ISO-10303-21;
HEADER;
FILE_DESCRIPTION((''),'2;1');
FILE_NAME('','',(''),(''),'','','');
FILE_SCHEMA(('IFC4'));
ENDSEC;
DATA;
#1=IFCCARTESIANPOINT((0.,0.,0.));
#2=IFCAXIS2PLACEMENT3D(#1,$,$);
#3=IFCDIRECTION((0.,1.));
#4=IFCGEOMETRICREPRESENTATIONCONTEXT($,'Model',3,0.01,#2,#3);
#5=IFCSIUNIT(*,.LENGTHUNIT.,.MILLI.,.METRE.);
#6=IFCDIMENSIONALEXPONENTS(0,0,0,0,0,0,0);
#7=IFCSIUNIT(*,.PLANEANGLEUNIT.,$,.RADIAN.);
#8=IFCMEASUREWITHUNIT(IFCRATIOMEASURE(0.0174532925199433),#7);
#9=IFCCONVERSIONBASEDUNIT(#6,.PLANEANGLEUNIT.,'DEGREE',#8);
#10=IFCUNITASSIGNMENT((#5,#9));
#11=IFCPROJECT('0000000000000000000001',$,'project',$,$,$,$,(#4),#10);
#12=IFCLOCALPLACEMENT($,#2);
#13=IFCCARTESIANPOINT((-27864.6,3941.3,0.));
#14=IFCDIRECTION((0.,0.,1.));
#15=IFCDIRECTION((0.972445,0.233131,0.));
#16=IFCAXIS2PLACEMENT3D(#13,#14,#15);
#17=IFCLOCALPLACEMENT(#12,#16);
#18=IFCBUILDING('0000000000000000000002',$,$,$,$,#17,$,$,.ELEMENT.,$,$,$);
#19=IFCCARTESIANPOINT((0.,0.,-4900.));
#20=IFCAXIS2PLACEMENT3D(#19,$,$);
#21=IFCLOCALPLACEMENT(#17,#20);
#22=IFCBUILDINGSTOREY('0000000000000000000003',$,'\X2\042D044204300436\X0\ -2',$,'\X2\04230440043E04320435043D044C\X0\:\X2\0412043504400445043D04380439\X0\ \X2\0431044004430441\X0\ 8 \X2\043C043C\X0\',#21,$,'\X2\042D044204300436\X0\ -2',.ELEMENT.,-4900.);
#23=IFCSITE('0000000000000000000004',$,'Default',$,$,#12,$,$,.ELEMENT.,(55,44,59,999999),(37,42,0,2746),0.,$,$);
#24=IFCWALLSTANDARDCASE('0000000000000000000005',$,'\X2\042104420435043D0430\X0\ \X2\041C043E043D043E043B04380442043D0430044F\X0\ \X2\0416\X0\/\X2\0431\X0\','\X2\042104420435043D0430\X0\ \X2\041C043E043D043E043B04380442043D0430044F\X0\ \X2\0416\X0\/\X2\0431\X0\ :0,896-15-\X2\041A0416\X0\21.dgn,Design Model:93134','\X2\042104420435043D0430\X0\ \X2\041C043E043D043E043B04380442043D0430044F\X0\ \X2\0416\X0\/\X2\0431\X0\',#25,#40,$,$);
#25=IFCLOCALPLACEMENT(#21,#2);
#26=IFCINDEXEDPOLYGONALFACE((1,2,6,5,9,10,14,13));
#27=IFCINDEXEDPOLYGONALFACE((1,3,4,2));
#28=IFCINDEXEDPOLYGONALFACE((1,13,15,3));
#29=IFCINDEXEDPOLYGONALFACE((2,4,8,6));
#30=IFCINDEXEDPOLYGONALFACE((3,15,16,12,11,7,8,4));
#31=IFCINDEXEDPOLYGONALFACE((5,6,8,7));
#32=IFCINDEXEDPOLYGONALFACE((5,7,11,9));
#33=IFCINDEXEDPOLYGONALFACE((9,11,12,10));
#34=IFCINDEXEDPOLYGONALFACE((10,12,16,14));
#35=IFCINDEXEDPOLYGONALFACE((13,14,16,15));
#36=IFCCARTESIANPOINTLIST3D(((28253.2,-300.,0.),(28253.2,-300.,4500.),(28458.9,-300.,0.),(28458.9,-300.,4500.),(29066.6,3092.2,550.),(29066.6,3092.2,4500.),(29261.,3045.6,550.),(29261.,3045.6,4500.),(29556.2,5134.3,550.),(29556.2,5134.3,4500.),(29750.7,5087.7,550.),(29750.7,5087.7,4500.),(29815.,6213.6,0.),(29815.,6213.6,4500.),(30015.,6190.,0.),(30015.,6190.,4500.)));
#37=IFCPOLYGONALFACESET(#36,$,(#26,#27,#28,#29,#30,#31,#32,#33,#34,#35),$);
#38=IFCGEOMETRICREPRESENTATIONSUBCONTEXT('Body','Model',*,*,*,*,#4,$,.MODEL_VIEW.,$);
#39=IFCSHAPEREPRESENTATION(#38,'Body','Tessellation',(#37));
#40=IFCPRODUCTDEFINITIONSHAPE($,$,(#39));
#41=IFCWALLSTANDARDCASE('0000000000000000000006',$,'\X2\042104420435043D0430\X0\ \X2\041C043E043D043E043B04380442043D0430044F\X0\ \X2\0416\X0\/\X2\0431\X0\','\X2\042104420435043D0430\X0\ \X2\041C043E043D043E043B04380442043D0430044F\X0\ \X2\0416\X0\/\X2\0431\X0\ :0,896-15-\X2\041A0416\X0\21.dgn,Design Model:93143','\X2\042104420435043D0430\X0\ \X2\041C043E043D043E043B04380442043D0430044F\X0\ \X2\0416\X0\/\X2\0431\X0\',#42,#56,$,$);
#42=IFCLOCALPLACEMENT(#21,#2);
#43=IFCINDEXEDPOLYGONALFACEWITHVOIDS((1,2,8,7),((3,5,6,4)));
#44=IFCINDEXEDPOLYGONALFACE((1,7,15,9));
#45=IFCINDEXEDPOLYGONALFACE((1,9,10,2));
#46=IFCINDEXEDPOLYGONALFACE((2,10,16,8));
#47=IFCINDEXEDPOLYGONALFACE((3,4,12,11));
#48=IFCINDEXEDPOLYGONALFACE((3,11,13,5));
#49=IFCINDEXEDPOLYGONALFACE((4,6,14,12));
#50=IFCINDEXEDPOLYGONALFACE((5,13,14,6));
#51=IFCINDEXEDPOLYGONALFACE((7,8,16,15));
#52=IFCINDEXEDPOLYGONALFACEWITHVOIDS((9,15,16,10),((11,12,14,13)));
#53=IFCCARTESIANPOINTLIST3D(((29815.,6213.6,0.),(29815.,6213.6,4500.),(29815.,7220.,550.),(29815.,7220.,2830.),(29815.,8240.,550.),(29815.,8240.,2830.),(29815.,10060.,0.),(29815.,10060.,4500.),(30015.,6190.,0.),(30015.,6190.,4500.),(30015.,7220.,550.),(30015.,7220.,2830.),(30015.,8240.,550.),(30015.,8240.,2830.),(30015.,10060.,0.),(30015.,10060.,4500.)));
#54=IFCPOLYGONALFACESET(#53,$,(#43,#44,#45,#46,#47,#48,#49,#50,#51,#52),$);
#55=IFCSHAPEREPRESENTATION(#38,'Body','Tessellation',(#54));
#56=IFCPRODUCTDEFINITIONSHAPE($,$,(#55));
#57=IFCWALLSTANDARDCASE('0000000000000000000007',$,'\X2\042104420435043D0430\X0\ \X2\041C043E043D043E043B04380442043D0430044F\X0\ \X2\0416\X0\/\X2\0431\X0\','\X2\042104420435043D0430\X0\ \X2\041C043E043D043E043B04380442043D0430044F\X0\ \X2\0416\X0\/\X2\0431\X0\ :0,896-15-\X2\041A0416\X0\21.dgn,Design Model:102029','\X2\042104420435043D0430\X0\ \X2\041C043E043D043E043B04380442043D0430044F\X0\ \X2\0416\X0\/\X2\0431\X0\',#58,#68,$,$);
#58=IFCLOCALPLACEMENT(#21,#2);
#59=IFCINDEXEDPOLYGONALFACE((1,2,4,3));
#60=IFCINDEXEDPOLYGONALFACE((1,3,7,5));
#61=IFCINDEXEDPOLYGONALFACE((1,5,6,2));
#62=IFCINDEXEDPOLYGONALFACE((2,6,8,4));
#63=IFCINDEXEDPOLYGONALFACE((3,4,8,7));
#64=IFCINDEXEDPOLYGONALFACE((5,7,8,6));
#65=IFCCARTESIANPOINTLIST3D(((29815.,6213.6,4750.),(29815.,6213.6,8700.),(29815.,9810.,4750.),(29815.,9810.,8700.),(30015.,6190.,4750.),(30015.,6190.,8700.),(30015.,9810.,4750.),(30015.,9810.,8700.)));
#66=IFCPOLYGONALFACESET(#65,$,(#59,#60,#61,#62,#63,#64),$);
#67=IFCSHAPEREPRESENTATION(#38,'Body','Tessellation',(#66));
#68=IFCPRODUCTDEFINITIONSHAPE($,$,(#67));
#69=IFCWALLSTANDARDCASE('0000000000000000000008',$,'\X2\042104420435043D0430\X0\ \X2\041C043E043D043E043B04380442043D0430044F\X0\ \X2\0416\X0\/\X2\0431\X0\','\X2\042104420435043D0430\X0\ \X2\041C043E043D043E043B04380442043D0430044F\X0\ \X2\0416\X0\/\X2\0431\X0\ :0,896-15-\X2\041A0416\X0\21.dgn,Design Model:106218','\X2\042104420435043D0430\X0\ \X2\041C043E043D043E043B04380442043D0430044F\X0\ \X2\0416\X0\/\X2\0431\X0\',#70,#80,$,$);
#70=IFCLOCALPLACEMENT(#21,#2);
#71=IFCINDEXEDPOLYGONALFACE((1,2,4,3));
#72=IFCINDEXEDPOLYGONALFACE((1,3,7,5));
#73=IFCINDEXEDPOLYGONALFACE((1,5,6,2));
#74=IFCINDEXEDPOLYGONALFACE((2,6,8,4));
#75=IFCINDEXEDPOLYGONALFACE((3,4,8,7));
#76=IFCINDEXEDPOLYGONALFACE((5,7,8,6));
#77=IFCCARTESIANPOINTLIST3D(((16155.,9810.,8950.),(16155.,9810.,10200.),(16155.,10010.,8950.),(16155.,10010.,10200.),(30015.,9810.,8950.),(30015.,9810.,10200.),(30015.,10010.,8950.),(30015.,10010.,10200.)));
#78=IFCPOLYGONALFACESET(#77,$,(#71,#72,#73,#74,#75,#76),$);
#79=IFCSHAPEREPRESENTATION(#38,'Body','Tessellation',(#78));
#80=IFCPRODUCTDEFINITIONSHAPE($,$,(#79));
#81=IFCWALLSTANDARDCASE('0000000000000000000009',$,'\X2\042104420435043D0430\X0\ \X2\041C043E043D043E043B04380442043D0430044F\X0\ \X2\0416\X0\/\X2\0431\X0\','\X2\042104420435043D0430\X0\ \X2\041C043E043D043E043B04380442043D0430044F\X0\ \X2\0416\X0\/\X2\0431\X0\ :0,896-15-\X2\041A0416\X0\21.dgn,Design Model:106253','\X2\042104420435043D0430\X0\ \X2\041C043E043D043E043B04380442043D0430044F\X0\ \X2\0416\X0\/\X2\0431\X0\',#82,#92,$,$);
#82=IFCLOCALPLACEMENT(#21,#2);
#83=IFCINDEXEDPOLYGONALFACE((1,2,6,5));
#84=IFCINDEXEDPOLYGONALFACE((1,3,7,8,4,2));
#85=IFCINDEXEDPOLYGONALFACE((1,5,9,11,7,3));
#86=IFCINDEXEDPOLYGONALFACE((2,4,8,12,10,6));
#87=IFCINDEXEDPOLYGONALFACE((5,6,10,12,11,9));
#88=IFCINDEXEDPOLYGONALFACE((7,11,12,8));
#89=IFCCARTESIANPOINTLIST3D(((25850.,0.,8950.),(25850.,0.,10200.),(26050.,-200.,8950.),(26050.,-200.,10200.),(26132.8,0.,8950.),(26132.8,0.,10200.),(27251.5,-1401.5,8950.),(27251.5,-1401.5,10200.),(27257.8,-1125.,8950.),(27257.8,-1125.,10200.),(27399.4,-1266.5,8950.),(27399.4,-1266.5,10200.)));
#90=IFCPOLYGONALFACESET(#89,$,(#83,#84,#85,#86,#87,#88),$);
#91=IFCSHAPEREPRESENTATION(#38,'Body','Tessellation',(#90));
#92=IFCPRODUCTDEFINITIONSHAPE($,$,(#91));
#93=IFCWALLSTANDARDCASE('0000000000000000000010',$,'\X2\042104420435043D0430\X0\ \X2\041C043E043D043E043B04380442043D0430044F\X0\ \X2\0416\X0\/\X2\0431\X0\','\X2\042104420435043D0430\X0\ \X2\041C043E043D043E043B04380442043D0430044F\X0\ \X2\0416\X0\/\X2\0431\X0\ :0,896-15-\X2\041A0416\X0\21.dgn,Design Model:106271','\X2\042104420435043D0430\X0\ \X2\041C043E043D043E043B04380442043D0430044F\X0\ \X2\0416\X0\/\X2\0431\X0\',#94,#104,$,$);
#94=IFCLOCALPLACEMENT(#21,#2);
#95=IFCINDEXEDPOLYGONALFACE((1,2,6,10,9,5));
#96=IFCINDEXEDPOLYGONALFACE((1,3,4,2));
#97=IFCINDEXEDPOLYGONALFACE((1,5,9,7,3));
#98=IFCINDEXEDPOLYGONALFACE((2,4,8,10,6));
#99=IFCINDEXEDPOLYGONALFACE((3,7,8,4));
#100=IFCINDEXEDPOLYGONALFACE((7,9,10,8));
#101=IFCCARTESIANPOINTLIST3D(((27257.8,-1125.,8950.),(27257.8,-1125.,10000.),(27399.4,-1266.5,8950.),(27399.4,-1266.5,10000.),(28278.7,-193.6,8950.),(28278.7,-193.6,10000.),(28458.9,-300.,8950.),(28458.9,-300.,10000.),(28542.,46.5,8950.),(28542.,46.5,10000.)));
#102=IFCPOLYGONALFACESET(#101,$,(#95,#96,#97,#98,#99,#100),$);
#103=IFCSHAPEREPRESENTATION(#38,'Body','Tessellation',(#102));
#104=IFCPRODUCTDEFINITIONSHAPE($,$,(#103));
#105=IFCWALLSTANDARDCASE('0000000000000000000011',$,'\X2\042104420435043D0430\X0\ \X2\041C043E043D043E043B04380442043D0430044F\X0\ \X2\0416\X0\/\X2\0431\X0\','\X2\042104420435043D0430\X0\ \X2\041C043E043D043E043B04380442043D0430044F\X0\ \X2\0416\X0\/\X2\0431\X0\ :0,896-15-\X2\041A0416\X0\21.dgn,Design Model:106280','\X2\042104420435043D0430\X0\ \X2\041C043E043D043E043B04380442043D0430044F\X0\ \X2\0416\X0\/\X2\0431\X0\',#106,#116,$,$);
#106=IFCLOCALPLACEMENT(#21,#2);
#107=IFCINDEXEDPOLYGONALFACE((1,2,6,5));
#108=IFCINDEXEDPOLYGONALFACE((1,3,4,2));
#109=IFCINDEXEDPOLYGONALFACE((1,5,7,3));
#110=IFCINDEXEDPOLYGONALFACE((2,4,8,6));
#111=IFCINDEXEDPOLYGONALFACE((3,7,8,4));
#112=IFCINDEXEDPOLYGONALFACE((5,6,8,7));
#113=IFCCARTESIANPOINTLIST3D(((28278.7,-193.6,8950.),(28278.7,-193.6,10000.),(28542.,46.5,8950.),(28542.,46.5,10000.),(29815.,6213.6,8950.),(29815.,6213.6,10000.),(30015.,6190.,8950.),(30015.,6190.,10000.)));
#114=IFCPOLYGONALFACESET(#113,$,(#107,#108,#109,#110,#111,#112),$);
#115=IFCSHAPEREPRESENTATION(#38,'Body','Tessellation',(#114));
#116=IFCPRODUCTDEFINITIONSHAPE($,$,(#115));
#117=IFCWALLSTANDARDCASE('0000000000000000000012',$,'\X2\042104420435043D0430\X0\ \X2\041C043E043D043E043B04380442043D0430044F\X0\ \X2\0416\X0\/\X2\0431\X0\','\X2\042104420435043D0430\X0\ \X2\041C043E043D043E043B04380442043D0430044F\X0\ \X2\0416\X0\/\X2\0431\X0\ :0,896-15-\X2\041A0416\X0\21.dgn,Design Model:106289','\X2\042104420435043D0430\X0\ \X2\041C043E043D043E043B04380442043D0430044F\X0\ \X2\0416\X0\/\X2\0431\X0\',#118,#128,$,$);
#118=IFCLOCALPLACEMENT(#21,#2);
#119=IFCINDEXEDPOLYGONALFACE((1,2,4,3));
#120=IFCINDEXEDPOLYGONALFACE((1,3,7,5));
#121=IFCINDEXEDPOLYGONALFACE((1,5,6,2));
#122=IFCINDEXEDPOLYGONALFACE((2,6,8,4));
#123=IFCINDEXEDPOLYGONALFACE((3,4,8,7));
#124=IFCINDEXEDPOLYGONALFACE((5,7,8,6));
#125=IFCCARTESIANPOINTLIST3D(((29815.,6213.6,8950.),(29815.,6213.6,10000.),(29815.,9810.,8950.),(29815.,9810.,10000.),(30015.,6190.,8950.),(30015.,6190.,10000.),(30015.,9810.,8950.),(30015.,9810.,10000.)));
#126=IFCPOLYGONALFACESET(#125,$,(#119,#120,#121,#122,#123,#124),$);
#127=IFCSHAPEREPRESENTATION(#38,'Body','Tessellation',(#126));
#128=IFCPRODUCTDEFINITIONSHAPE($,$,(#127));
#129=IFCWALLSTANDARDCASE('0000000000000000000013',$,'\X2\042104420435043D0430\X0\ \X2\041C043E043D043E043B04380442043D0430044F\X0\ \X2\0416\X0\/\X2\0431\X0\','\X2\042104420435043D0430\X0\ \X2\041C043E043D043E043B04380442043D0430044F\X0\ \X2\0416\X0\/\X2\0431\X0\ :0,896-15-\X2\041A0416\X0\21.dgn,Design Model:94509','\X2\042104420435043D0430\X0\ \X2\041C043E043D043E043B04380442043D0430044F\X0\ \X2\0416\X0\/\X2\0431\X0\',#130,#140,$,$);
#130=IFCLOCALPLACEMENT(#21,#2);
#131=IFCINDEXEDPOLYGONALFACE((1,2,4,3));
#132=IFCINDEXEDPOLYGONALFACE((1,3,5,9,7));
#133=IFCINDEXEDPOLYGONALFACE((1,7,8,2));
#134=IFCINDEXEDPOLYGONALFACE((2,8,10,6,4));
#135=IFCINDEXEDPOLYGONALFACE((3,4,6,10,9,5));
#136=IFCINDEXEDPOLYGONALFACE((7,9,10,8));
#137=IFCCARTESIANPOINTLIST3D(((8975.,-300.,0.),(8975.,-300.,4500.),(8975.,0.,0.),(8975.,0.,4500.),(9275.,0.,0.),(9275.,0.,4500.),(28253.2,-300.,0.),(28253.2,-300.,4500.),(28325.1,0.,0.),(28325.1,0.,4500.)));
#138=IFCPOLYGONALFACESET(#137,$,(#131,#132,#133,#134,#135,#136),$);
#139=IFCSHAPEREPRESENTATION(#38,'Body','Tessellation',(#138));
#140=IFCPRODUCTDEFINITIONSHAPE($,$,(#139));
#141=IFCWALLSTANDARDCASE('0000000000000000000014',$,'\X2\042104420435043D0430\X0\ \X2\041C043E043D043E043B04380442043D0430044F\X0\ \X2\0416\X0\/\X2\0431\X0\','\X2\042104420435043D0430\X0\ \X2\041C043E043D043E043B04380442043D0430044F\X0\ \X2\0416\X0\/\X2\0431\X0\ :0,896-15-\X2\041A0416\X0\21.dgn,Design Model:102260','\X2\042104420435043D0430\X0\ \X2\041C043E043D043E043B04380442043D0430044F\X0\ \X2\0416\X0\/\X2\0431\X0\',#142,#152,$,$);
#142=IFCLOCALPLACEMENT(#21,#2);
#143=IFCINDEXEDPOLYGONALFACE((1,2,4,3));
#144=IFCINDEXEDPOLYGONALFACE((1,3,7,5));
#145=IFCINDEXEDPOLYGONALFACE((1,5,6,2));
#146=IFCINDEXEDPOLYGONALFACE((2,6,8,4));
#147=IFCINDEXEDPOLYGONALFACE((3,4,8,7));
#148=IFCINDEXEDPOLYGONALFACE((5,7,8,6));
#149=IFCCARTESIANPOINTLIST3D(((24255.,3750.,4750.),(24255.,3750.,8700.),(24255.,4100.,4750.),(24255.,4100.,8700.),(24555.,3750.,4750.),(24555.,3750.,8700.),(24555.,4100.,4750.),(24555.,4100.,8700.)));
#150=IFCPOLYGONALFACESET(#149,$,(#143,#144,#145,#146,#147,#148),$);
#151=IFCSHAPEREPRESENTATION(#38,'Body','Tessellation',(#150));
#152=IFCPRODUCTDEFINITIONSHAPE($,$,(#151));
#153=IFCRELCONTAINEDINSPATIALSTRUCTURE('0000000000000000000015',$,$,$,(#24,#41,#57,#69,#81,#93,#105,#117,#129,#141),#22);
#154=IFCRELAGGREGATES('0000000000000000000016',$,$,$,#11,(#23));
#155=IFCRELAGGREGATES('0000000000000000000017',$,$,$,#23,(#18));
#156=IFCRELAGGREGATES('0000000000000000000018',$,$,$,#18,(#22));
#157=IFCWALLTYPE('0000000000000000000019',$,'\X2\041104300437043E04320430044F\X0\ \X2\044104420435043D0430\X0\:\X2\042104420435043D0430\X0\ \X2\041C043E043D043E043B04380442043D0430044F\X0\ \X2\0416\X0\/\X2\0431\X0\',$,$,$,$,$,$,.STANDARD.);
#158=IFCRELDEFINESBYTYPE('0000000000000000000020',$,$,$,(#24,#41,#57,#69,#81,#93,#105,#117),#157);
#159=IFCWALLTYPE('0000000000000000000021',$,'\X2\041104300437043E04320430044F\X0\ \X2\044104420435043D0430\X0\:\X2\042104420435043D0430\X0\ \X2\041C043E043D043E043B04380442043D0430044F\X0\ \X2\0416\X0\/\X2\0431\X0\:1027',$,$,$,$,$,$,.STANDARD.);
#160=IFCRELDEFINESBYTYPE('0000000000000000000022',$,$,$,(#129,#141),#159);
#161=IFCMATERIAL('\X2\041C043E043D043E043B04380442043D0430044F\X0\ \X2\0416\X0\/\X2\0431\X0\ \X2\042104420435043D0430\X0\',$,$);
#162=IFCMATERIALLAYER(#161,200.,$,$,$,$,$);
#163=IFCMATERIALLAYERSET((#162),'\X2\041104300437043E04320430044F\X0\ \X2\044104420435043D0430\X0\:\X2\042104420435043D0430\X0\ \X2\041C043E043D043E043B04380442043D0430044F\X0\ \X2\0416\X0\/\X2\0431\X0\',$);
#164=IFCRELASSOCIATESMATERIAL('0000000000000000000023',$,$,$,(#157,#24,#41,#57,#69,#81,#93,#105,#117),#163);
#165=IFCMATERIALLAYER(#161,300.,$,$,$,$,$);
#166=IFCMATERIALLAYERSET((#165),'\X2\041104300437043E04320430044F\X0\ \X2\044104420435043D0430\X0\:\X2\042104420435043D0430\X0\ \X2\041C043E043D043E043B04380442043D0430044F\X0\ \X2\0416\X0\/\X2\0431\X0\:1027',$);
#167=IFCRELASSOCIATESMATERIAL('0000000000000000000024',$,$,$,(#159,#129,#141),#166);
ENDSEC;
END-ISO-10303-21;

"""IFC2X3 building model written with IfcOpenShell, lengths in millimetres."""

from ifc_helpers import new_model, entity, si_unit, converted_unit, direction, frame, frame_2d, origin, origin_2d_with_axis, place, context, subcontext, project, spatial, polyline, rectangle, outline, extrude, material, layer, layer_set, layer_usage, type_object, element, save


model = new_model("IFC2X3")

# Units and contexts
model_context = context("Model", 3, precision=0.01, world=origin(), true_north=direction((0.0, 1.0)))
body_context = subcontext(model_context, "Body", "Model", "MODEL_VIEW")
ifc_project = project(units=[si_unit("LENGTHUNIT", "METRE", prefix="MILLI"), converted_unit("PLANEANGLEUNIT", "DEGREE", entity("IfcRatioMeasure", 0.0174532925199433), si_unit("PLANEANGLEUNIT", "RADIAN"), dimensions=[0, 0, 0, 0, 0, 0, 0])], contexts=[model_context])

# Site, building, storey
site_placement = place(None, origin())
site = spatial("IfcSite", under=ifc_project, at=site_placement, Name="Default", CompositionType="ELEMENT", RefLatitude=(55, 44, 59, 999999), RefLongitude=(37, 42, 0, 2746), RefElevation=0.0)
building_placement = place(site_placement, frame((-27864.6, 3941.3, 0.0), z_axis=(0.0, 0.0, 1.0), x_axis=(0.972445, 0.233131, 0.0)))
building = spatial("IfcBuilding", under=site, at=building_placement, CompositionType="ELEMENT")
storey_placement = place(building_placement, frame((0.0, 0.0, -4900.0)))
storey = spatial("IfcBuildingStorey", under=building, at=storey_placement, Name="Этаж -2", ObjectType="Уровень:Верхний брус 8 мм", LongName="Этаж -2", CompositionType="ELEMENT", Elevation=-4900.0)

# Walls, openings
ifc_material = material(Name="Монолитная Ж/б Стена")
ifc_layer_1 = layer(ifc_material, 200.0)
ifc_layer_set_1 = layer_set([ifc_layer_1], Name="Базовая стена:Стена Монолитная Ж/б")
ifc_layer_usage_1 = layer_usage(ifc_layer_set_1, "AXIS2", "NEGATIVE", 100.0)
wall_type_1 = type_object("IfcWallType", Name="Базовая стена:Стена Монолитная Ж/б", PredefinedType="STANDARD", material=ifc_layer_set_1)
wall_1_placement = place(storey_placement, frame((29917.8, 6213.3, 0.0), z_axis=(0.0, 0.0, 1.0), x_axis=(-0.233165, -0.972437, 0.0)))
wall_1 = element("IfcWallStandardCase", 1, at=wall_1_placement, inside=storey, type_object=wall_type_1, material=ifc_layer_usage_1, Name="Стена Монолитная Ж/б", Description="Стена Монолитная Ж/б :0,896-15-КЖ21.dgn,Design Model:93134", ObjectType="Стена Монолитная Ж/б", context=body_context, shape_type="SweptSolid", body=[
    extrude(outline(polyline([(6721.9, -100.0), (6673.9, 100.0), (0.0, 100.0), (23.6, -100.0), (3343.4, -100.0), (3593.4, -100.0), (6413.4, -100.0), (6721.9, -100.0)])), origin(), (0.0, 0.0, 1.0), 4500.0),
])
opening_1_placement = place(wall_1_placement, origin())
element("IfcOpeningElement", 2, at=opening_1_placement, cuts=wall_1, ObjectType="Opening", context=body_context, shape_type="SweptSolid", body=[
    extrude(rectangle(XDim=3950.0, YDim=2100.0, at=origin_2d_with_axis()), frame((2183.6, -100.0, 2525.0), z_axis=(0.0, 1.0, 0.0), x_axis=(0.0, 0.0, -1.0)), (0.0, 0.0, 1.0), 200.0),
])
wall_2_placement = place(storey_placement, frame((29915.0, 10060.0, 0.0), z_axis=(0.0, 0.0, 1.0), x_axis=(0.0, -1.0, 0.0)))
wall_2 = element("IfcWallStandardCase", 3, at=wall_2_placement, inside=storey, type_object=wall_type_1, material=ifc_layer_usage_1, Name="Стена Монолитная Ж/б", Description="Стена Монолитная Ж/б :0,896-15-КЖ21.dgn,Design Model:93143", ObjectType="Стена Монолитная Ж/б", context=body_context, shape_type="SweptSolid", body=[
    extrude(outline(polyline([(3846.4, -100.0), (3870.0, 100.0), (0.0, 100.0), (0.0, -100.0), (300.0, -100.0), (3846.4, -100.0)])), origin(), (0.0, 0.0, 1.0), 4500.0),
])
opening_2_placement = place(wall_2_placement, origin())
element("IfcOpeningElement", 4, at=opening_2_placement, cuts=wall_2, ObjectType="Opening", context=body_context, shape_type="SweptSolid", body=[
    extrude(rectangle(XDim=2280.0, YDim=1020.0, at=origin_2d_with_axis()), frame((2330.0, -100.0, 1690.0), z_axis=(0.0, 1.0, 0.0), x_axis=(0.0, 0.0, -1.0)), (0.0, 0.0, 1.0), 200.0),
])

# Walls
wall_3_placement = place(storey_placement, frame((29915.0, 6190.0, 4750.0), z_axis=(0.0, 0.0, 1.0), x_axis=(0.0, 1.0, 0.0)))
element("IfcWallStandardCase", 5, at=wall_3_placement, inside=storey, type_object=wall_type_1, material=ifc_layer_usage_1, Name="Стена Монолитная Ж/б", Description="Стена Монолитная Ж/б :0,896-15-КЖ21.dgn,Design Model:102029", ObjectType="Стена Монолитная Ж/б", context=body_context, shape_type="SweptSolid", body=[
    extrude(outline(polyline([(3620.0, -100.0), (3620.0, 100.0), (23.6, 100.0), (0.0, -100.0), (3620.0, -100.0)])), origin(), (0.0, 0.0, 1.0), 3950.0),
])
wall_4_placement = place(storey_placement, frame((30015.0, 9910.0, 8950.0), z_axis=(0.0, 0.0, 1.0), x_axis=(-1.0, 0.0, 0.0)))
element("IfcWallStandardCase", 6, at=wall_4_placement, inside=storey, type_object=wall_type_1, material=ifc_layer_usage_1, Name="Стена Монолитная Ж/б", Description="Стена Монолитная Ж/б :0,896-15-КЖ21.dgn,Design Model:106218", ObjectType="Стена Монолитная Ж/б", context=body_context, shape_type="SweptSolid", body=[
    extrude(rectangle(XDim=13860.0, YDim=200.0, at=frame_2d((6930.0, 0.0), x_axis=(-1.0, 0.0))), origin(), (0.0, 0.0, 1.0), 1250.0),
])
wall_5_placement = place(storey_placement, frame((25920.7, 70.7, 8950.0), z_axis=(0.0, 0.0, 1.0), x_axis=(0.707107, -0.707107, 0.0)))
element("IfcWallStandardCase", 7, at=wall_5_placement, inside=storey, type_object=wall_type_1, material=ifc_layer_usage_1, Name="Стена Монолитная Ж/б", Description="Стена Монолитная Ж/б :0,896-15-КЖ21.dgn,Design Model:106253", ObjectType="Стена Монолитная Ж/б", context=body_context, shape_type="SweptSolid", body=[
    extrude(outline(polyline([(1982.0, -100.0), (1991.2, 100.0), (1791.0, 100.0), (200.0, 100.0), (0.0, -100.0), (282.8, -100.0), (1982.0, -100.0)])), origin(), (0.0, 0.0, 1.0), 1250.0),
])
wall_6_placement = place(storey_placement, frame((28609.3, -27.4, 8950.0), z_axis=(0.0, 0.0, 1.0), x_axis=(-0.738765, -0.673963, 0.0)))
element("IfcWallStandardCase", 8, at=wall_6_placement, inside=storey, type_object=wall_type_1, material=ifc_layer_usage_1, Name="Стена Монолитная Ж/б", Description="Стена Монолитная Ж/б :0,896-15-КЖ21.dgn,Design Model:106271", ObjectType="Стена Монолитная Ж/б", context=body_context, shape_type="SweptSolid", body=[
    extrude(outline(polyline([(1738.2, -100.0), (1729.0, 100.0), (294.9, 100.0), (0.0, -100.0), (356.3, -100.0), (1738.2, -100.0)])), origin(), (0.0, 0.0, 1.0), 1050.0),
])
wall_7_placement = place(storey_placement, frame((29917.8, 6213.3, 8950.0), z_axis=(0.0, 0.0, 1.0), x_axis=(-0.233165, -0.972437, 0.0)))
element("IfcWallStandardCase", 9, at=wall_7_placement, inside=storey, type_object=wall_type_1, material=ifc_layer_usage_1, Name="Стена Монолитная Ж/б", Description="Стена Монолитная Ж/б :0,896-15-КЖ21.dgn,Design Model:106280", ObjectType="Стена Монолитная Ж/б", context=body_context, shape_type="SweptSolid", body=[
    extrude(outline(polyline([(6612.5, -100.0), (6317.6, 100.0), (0.0, 100.0), (23.6, -100.0), (6612.5, -100.0)])), origin(), (0.0, 0.0, 1.0), 1050.0),
])
wall_8_placement = place(storey_placement, frame((29915.0, 9810.0, 8950.0), z_axis=(0.0, 0.0, 1.0), x_axis=(0.0, -1.0, 0.0)))
element("IfcWallStandardCase", 10, at=wall_8_placement, inside=storey, type_object=wall_type_1, material=ifc_layer_usage_1, Name="Стена Монолитная Ж/б", Description="Стена Монолитная Ж/б :0,896-15-КЖ21.dgn,Design Model:106289", ObjectType="Стена Монолитная Ж/б", context=body_context, shape_type="SweptSolid", body=[
    extrude(outline(polyline([(3596.4, -100.0), (3620.0, 100.0), (0.0, 100.0), (0.0, -100.0), (3596.4, -100.0)])), origin(), (0.0, 0.0, 1.0), 1050.0),
])
ifc_layer_2 = layer(ifc_material, 300.0)
ifc_layer_set_2 = layer_set([ifc_layer_2], Name="Базовая стена:Стена Монолитная Ж/б:1027")
ifc_layer_usage_2 = layer_usage(ifc_layer_set_2, "AXIS2", "NEGATIVE", 150.0)
wall_type_2 = type_object("IfcWallType", Name="Базовая стена:Стена Монолитная Ж/б:1027", PredefinedType="STANDARD", material=ifc_layer_set_2)
wall_9_placement = place(storey_placement, frame((28325.1, -150.0, 0.0), z_axis=(0.0, 0.0, 1.0), x_axis=(-1.0, 0.0, 0.0)))
element("IfcWallStandardCase", 11, at=wall_9_placement, inside=storey, type_object=wall_type_2, material=ifc_layer_usage_2, Name="Стена Монолитная Ж/б", Description="Стена Монолитная Ж/б :0,896-15-КЖ21.dgn,Design Model:94509", ObjectType="Стена Монолитная Ж/б", context=body_context, shape_type="SweptSolid", body=[
    extrude(outline(polyline([(19350.1, -150.0), (19350.1, 150.0), (71.9, 150.0), (0.0, -150.0), (19050.1, -150.0), (19350.1, -150.0)])), origin(), (0.0, 0.0, 1.0), 4500.0),
])
wall_10_placement = place(storey_placement, frame((24405.0, 4100.0, 4750.0), z_axis=(0.0, 0.0, 1.0), x_axis=(0.0, -1.0, 0.0)))
element("IfcWallStandardCase", 12, at=wall_10_placement, inside=storey, type_object=wall_type_2, material=ifc_layer_usage_2, Name="Стена Монолитная Ж/б", Description="Стена Монолитная Ж/б :0,896-15-КЖ21.dgn,Design Model:102260", ObjectType="Стена Монолитная Ж/б", context=body_context, shape_type="SweptSolid", body=[
    extrude(rectangle(XDim=350.0, YDim=300.0, at=frame_2d((175.0, 0.0), x_axis=(-1.0, 0.0))), origin(), (0.0, 0.0, 1.0), 3950.0),
])

save(model, "model.ifc")
